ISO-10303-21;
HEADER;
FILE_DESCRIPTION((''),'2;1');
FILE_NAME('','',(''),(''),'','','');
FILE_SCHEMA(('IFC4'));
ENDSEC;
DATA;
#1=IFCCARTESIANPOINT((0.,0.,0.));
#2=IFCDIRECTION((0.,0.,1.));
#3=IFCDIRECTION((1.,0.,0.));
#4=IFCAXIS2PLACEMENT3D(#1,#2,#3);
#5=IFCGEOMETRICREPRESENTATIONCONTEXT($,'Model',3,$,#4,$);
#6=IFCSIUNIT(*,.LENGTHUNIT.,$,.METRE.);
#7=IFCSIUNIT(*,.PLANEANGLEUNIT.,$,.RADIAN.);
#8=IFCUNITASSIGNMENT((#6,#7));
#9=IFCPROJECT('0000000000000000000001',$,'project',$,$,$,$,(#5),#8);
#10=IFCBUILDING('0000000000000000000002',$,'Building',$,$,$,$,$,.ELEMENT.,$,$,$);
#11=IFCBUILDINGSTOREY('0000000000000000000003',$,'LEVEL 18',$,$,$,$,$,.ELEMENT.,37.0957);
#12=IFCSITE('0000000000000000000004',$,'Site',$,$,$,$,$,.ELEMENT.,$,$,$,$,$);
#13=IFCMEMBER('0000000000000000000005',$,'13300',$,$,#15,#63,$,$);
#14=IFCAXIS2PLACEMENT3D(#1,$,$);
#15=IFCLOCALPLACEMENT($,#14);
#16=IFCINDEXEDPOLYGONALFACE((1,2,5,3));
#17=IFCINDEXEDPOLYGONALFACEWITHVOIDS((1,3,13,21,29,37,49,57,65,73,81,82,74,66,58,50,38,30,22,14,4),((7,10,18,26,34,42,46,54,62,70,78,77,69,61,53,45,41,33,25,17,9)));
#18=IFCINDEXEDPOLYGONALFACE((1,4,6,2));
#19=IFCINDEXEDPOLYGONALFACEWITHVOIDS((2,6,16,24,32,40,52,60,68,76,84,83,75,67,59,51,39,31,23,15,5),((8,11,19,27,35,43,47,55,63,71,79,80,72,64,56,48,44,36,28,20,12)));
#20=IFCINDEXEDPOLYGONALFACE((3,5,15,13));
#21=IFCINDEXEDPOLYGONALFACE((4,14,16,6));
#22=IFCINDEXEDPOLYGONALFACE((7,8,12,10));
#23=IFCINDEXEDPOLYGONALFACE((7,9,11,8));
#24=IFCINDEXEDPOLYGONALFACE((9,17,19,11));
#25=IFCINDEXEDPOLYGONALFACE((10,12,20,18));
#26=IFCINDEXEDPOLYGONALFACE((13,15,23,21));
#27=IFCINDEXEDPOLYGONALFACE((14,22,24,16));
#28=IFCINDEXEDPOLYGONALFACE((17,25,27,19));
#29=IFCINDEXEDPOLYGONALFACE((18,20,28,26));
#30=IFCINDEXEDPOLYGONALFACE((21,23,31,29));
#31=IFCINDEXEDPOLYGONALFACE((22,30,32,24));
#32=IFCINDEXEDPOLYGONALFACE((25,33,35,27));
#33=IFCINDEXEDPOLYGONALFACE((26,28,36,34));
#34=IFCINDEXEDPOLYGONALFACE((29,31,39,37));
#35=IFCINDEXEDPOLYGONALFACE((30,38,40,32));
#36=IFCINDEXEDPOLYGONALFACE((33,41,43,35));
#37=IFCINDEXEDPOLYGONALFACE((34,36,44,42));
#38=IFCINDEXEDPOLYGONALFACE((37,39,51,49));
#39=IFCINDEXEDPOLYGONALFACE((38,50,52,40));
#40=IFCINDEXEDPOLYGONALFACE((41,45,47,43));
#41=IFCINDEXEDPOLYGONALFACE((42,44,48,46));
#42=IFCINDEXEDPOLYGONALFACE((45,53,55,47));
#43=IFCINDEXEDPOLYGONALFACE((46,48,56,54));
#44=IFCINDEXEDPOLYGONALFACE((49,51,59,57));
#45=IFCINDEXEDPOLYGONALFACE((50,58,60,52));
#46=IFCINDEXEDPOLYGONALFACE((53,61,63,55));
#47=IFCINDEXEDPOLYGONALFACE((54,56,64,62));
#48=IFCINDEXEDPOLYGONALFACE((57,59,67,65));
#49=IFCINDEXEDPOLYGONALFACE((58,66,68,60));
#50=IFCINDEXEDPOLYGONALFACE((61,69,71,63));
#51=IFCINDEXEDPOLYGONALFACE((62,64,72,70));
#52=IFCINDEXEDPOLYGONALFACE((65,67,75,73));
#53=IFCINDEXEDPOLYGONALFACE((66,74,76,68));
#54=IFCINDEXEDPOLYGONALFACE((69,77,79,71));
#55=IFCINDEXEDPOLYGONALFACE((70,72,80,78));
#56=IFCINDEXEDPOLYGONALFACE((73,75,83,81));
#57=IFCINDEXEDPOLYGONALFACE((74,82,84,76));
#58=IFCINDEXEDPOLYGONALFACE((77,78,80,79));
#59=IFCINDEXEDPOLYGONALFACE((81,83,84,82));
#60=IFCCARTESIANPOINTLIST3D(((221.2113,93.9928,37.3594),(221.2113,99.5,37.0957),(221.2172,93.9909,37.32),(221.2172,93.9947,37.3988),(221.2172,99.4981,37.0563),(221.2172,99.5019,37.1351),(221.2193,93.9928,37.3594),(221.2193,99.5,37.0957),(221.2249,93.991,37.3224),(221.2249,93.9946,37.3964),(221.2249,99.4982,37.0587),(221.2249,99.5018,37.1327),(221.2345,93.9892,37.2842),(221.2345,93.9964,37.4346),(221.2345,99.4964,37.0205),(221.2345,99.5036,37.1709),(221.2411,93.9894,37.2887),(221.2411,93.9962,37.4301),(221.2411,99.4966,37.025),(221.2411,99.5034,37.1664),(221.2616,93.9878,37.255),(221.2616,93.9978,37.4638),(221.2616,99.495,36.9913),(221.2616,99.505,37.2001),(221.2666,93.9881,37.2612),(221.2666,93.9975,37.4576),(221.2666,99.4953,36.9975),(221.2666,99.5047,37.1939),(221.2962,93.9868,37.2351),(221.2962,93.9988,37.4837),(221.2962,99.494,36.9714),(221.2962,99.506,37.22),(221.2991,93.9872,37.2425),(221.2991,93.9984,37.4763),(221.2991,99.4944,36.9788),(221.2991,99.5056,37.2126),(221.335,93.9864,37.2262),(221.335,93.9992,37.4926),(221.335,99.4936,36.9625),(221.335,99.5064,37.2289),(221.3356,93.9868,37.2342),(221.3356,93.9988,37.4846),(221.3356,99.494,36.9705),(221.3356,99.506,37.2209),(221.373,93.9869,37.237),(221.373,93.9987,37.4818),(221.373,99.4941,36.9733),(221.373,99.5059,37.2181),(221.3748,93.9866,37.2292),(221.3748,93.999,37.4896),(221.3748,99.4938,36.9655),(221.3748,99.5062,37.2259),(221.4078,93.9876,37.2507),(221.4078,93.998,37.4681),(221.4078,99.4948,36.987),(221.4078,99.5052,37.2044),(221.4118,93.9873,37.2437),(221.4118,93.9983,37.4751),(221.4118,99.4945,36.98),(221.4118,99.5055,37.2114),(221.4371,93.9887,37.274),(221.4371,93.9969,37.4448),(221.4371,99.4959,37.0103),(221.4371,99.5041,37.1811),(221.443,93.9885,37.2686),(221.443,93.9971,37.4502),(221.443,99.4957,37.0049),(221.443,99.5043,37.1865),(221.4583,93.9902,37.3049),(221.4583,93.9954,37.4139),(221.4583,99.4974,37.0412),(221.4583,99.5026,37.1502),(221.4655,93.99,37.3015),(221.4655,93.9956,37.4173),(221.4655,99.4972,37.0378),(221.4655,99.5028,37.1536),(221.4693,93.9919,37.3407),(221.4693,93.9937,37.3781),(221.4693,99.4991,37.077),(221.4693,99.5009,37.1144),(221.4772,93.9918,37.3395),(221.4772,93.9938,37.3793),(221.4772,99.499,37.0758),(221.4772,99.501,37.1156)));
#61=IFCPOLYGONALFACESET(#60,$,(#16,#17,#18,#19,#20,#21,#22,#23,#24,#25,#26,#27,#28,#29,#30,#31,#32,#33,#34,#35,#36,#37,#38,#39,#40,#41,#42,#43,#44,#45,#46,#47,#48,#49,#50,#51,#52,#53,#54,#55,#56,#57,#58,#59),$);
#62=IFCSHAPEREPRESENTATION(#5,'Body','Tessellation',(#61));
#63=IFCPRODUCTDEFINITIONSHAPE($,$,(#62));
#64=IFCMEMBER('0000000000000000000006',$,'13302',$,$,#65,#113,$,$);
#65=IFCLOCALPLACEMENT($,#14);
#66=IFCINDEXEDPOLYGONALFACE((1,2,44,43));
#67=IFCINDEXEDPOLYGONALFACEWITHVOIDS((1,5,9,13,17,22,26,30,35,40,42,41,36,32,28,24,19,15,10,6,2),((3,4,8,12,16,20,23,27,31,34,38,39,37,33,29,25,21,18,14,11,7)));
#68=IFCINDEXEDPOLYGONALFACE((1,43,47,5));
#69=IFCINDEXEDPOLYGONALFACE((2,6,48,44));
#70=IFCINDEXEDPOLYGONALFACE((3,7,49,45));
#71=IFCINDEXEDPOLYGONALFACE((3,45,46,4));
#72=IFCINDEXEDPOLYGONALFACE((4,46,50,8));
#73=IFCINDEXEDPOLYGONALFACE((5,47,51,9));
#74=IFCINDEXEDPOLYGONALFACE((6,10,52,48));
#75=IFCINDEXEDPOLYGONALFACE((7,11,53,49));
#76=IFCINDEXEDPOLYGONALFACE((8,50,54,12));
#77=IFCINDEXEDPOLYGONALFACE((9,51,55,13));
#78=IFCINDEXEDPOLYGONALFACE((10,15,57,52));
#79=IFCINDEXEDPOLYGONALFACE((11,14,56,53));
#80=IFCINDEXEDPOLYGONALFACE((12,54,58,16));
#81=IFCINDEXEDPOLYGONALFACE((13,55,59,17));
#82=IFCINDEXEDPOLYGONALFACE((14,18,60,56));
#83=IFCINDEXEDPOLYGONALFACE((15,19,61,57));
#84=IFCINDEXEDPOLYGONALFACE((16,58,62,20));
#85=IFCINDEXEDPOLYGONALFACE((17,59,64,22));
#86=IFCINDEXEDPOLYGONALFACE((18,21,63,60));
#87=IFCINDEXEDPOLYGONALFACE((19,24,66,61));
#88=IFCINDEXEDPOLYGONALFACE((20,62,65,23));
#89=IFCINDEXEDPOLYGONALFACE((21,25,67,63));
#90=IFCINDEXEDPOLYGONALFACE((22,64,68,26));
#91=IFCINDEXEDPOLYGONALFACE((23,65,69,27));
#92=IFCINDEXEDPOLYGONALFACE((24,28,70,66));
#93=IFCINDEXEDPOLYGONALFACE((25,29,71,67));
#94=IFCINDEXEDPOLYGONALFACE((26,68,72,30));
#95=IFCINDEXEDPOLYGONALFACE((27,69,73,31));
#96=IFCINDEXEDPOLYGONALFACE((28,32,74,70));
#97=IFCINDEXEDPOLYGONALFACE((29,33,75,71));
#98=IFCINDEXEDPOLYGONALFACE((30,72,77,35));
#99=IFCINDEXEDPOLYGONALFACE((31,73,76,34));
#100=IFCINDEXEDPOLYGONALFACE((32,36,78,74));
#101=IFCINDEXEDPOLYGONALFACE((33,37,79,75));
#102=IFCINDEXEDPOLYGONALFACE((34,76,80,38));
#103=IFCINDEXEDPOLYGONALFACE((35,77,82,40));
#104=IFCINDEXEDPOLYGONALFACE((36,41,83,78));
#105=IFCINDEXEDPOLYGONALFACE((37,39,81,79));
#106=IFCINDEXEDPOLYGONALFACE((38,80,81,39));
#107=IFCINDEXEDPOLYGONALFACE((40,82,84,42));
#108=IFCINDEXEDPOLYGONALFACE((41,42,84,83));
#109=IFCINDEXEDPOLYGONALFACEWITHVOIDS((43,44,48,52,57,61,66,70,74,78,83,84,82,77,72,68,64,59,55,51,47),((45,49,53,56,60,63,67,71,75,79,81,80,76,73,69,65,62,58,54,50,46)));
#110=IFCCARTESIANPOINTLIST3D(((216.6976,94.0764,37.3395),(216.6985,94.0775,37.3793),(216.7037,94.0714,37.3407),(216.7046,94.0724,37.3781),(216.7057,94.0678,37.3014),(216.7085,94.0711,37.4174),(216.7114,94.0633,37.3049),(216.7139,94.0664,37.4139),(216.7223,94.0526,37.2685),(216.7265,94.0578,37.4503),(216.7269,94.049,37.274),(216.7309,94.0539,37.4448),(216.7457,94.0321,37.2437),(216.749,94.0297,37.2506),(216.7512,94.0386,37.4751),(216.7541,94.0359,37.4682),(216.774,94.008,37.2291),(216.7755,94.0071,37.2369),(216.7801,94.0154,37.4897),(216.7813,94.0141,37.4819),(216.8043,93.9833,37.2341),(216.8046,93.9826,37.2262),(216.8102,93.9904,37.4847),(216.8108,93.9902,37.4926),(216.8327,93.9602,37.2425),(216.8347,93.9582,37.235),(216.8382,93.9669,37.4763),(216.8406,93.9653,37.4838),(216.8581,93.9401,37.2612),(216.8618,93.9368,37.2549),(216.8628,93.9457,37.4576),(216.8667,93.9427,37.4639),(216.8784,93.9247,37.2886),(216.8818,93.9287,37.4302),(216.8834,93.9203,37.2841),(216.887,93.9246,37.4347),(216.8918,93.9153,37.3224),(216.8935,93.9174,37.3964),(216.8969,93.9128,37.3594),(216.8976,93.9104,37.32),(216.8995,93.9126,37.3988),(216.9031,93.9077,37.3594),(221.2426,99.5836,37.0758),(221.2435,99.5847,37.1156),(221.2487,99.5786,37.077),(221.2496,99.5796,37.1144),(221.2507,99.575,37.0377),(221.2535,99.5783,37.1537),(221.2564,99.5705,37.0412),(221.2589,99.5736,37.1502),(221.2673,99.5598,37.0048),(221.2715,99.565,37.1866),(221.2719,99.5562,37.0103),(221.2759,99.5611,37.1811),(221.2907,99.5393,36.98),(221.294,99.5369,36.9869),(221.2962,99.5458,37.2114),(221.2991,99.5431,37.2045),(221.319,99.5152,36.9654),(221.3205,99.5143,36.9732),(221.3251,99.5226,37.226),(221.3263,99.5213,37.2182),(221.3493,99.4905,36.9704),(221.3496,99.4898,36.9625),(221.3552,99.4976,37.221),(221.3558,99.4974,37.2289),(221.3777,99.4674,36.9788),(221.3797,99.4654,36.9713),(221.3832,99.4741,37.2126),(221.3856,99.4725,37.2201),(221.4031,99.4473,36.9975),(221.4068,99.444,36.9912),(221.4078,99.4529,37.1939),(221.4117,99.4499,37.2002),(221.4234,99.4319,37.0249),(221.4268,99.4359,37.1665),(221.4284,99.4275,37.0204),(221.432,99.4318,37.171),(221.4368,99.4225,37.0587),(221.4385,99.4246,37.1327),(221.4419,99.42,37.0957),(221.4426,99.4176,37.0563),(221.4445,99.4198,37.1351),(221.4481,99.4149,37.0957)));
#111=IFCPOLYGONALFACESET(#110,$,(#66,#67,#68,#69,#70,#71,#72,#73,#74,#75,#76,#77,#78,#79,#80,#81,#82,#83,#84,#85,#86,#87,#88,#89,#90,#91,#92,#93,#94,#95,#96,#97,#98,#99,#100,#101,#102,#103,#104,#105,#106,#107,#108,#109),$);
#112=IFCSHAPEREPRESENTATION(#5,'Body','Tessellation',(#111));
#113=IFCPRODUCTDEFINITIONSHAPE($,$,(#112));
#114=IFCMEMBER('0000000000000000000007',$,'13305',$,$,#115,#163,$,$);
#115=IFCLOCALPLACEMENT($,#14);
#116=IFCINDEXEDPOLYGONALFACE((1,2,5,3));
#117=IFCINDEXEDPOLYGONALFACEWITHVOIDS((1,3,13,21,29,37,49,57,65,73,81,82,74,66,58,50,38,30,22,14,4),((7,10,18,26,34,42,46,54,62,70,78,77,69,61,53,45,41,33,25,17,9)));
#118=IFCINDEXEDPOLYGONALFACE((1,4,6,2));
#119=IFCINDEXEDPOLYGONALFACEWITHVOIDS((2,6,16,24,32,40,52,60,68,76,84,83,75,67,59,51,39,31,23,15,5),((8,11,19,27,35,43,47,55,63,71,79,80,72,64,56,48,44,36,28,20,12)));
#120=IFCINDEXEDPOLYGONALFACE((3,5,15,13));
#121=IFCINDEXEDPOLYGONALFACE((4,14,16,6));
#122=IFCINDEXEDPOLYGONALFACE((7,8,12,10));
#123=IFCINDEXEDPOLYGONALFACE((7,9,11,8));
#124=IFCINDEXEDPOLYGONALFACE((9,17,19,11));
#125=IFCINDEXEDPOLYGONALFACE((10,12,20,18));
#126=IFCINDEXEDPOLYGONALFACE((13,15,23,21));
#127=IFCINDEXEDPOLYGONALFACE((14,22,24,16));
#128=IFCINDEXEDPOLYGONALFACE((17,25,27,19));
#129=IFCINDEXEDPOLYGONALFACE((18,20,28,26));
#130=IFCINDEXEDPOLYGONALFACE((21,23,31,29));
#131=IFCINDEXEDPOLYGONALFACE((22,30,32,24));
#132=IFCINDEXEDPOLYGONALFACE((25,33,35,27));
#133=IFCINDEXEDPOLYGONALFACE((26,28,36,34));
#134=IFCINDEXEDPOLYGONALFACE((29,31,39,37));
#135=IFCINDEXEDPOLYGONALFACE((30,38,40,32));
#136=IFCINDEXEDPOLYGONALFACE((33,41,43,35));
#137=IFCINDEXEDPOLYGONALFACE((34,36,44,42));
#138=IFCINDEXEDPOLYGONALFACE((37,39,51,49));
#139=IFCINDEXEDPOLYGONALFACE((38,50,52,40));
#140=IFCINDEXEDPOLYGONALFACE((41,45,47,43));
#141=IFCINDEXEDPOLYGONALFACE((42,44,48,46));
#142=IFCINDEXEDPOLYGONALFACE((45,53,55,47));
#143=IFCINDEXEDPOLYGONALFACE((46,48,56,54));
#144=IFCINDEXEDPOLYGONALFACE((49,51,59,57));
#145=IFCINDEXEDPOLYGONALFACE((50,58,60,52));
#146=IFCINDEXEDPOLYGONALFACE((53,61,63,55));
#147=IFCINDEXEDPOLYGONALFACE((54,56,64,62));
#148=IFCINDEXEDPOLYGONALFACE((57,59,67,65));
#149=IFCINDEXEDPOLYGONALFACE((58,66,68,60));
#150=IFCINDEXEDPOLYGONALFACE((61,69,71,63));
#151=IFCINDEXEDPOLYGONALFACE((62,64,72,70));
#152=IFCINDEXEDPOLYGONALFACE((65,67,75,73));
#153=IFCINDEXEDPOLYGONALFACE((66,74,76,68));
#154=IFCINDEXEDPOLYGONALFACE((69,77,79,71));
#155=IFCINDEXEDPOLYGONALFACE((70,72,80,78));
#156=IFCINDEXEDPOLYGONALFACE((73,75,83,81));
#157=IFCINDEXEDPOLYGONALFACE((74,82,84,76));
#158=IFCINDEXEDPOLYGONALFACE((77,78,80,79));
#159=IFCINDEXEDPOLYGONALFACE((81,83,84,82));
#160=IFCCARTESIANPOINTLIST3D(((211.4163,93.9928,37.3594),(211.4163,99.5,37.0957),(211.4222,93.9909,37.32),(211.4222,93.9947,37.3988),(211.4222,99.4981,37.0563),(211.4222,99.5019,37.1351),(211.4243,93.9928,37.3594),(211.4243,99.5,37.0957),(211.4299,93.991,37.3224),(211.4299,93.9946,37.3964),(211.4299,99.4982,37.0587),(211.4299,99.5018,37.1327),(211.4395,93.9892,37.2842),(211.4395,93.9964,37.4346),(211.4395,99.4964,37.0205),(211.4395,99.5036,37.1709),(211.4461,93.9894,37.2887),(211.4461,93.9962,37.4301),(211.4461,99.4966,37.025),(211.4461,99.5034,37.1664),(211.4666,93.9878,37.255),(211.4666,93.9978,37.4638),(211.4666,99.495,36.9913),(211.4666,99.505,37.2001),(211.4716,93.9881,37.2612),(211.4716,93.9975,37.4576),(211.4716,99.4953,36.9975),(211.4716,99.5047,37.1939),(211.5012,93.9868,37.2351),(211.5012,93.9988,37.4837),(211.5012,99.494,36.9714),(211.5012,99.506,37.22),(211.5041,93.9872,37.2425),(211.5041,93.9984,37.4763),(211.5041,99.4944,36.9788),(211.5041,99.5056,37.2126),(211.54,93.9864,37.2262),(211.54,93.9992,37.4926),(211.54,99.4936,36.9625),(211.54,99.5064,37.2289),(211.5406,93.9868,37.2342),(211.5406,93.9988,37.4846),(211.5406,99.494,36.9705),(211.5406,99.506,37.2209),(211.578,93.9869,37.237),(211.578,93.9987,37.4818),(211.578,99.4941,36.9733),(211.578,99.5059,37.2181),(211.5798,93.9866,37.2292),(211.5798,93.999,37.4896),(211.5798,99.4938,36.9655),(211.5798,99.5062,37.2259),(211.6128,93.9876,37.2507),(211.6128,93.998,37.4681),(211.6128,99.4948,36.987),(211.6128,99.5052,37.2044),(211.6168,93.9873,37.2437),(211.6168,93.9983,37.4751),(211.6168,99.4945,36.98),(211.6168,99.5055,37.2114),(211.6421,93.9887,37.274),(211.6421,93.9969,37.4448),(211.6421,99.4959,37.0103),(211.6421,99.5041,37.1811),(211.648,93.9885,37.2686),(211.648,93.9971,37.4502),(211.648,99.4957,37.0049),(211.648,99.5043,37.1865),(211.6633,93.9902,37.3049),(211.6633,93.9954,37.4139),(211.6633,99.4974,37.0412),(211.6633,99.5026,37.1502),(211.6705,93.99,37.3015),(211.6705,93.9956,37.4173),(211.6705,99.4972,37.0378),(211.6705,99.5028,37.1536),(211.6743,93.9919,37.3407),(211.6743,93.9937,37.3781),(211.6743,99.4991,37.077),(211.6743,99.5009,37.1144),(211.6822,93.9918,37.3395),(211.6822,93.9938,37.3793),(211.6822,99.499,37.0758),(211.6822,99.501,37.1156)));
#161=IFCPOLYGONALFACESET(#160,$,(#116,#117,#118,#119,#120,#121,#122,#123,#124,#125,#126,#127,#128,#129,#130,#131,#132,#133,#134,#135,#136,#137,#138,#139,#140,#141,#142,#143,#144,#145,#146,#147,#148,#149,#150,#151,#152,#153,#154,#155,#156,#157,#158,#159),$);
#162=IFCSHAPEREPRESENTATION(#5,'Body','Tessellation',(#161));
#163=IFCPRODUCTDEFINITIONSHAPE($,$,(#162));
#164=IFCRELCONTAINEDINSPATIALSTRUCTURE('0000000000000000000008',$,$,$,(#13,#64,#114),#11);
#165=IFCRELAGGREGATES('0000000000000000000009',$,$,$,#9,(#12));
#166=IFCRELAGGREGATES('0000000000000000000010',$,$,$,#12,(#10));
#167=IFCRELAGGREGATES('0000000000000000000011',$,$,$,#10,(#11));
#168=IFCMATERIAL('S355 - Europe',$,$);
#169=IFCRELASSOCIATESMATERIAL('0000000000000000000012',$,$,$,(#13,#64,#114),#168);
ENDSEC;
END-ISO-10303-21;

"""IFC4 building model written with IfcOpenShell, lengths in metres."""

from ifc_helpers import new_model, si_unit, frame, origin_with_axes, origin_2d_with_axis, place, context, project, spatial, hollow_circle, extrude, material, material_profile, profile_set, profile_usage, element, save


model = new_model("IFC4")

# Units and contexts
model_context = context("Model", 3, world=origin_with_axes())
ifc_project = project(units=[si_unit("LENGTHUNIT", "METRE"), si_unit("PLANEANGLEUNIT", "RADIAN")], contexts=[model_context])

# Site, building, storey
site = spatial("IfcSite", under=ifc_project, Name="Site", CompositionType="ELEMENT")
building = spatial("IfcBuilding", under=site, Name="Building", CompositionType="ELEMENT")
storey = spatial("IfcBuildingStorey", under=building, Name="LEVEL 18", CompositionType="ELEMENT", Elevation=37.0957)

# Shared definitions
ifc_material = material(Name="S355 - Europe")

# Members
ifc_material_profile_1 = material_profile(ifc_material, hollow_circle(Radius=0.1337, WallThickness=0.008, at=origin_2d_with_axis()))
ifc_profile_set_1 = profile_set([ifc_material_profile_1])
ifc_profile_usage_1 = profile_usage(ifc_profile_set_1, cardinal=10)
member_1_placement = place(None, frame((221.345, 93.9928, 37.3594), z_axis=(0.0, 0.998856, -0.047828), x_axis=(-1.0, 0.0, 0.0)))
element("IfcMember", 1, at=member_1_placement, inside=storey, material=ifc_profile_usage_1, Name="13300", context=model_context, shape_type="SweptSolid", body=[
    extrude(hollow_circle(Radius=0.1337, WallThickness=0.008, at=origin_2d_with_axis()), origin_with_axes(), (0.0, 0.0, 1.0), 5.5135),
])
ifc_material_profile_2 = material_profile(ifc_material, hollow_circle(Radius=0.1337, WallThickness=0.008, at=origin_2d_with_axis()))
ifc_profile_set_2 = profile_set([ifc_material_profile_2])
ifc_profile_usage_2 = profile_usage(ifc_profile_set_2, cardinal=10)
member_2_placement = place(None, frame((221.345, 99.5, 37.0957), z_axis=(-0.636079, -0.770741, 0.036905), x_axis=(0.771137, -0.636669, 0.0)))
element("IfcMember", 2, at=member_2_placement, inside=storey, material=ifc_profile_usage_2, Name="13302", context=model_context, shape_type="SweptSolid", body=[
    extrude(hollow_circle(Radius=0.1337, WallThickness=0.008, at=origin_2d_with_axis()), origin_with_axes(), (0.0, 0.0, 1.0), 7.1453),
])
ifc_material_profile_3 = material_profile(ifc_material, hollow_circle(Radius=0.1337, WallThickness=0.008, at=origin_2d_with_axis()))
ifc_profile_set_3 = profile_set([ifc_material_profile_3])
ifc_profile_usage_3 = profile_usage(ifc_profile_set_3, cardinal=10)
member_3_placement = place(None, frame((211.55, 93.9928, 37.3594), z_axis=(0.0, 0.998856, -0.047828), x_axis=(-1.0, 0.0, 0.0)))
element("IfcMember", 3, at=member_3_placement, inside=storey, material=ifc_profile_usage_3, Name="13305", context=model_context, shape_type="SweptSolid", body=[
    extrude(hollow_circle(Radius=0.1337, WallThickness=0.008, at=origin_2d_with_axis()), origin_with_axes(), (0.0, 0.0, 1.0), 5.5135),
])

save(model, "model.ifc")
